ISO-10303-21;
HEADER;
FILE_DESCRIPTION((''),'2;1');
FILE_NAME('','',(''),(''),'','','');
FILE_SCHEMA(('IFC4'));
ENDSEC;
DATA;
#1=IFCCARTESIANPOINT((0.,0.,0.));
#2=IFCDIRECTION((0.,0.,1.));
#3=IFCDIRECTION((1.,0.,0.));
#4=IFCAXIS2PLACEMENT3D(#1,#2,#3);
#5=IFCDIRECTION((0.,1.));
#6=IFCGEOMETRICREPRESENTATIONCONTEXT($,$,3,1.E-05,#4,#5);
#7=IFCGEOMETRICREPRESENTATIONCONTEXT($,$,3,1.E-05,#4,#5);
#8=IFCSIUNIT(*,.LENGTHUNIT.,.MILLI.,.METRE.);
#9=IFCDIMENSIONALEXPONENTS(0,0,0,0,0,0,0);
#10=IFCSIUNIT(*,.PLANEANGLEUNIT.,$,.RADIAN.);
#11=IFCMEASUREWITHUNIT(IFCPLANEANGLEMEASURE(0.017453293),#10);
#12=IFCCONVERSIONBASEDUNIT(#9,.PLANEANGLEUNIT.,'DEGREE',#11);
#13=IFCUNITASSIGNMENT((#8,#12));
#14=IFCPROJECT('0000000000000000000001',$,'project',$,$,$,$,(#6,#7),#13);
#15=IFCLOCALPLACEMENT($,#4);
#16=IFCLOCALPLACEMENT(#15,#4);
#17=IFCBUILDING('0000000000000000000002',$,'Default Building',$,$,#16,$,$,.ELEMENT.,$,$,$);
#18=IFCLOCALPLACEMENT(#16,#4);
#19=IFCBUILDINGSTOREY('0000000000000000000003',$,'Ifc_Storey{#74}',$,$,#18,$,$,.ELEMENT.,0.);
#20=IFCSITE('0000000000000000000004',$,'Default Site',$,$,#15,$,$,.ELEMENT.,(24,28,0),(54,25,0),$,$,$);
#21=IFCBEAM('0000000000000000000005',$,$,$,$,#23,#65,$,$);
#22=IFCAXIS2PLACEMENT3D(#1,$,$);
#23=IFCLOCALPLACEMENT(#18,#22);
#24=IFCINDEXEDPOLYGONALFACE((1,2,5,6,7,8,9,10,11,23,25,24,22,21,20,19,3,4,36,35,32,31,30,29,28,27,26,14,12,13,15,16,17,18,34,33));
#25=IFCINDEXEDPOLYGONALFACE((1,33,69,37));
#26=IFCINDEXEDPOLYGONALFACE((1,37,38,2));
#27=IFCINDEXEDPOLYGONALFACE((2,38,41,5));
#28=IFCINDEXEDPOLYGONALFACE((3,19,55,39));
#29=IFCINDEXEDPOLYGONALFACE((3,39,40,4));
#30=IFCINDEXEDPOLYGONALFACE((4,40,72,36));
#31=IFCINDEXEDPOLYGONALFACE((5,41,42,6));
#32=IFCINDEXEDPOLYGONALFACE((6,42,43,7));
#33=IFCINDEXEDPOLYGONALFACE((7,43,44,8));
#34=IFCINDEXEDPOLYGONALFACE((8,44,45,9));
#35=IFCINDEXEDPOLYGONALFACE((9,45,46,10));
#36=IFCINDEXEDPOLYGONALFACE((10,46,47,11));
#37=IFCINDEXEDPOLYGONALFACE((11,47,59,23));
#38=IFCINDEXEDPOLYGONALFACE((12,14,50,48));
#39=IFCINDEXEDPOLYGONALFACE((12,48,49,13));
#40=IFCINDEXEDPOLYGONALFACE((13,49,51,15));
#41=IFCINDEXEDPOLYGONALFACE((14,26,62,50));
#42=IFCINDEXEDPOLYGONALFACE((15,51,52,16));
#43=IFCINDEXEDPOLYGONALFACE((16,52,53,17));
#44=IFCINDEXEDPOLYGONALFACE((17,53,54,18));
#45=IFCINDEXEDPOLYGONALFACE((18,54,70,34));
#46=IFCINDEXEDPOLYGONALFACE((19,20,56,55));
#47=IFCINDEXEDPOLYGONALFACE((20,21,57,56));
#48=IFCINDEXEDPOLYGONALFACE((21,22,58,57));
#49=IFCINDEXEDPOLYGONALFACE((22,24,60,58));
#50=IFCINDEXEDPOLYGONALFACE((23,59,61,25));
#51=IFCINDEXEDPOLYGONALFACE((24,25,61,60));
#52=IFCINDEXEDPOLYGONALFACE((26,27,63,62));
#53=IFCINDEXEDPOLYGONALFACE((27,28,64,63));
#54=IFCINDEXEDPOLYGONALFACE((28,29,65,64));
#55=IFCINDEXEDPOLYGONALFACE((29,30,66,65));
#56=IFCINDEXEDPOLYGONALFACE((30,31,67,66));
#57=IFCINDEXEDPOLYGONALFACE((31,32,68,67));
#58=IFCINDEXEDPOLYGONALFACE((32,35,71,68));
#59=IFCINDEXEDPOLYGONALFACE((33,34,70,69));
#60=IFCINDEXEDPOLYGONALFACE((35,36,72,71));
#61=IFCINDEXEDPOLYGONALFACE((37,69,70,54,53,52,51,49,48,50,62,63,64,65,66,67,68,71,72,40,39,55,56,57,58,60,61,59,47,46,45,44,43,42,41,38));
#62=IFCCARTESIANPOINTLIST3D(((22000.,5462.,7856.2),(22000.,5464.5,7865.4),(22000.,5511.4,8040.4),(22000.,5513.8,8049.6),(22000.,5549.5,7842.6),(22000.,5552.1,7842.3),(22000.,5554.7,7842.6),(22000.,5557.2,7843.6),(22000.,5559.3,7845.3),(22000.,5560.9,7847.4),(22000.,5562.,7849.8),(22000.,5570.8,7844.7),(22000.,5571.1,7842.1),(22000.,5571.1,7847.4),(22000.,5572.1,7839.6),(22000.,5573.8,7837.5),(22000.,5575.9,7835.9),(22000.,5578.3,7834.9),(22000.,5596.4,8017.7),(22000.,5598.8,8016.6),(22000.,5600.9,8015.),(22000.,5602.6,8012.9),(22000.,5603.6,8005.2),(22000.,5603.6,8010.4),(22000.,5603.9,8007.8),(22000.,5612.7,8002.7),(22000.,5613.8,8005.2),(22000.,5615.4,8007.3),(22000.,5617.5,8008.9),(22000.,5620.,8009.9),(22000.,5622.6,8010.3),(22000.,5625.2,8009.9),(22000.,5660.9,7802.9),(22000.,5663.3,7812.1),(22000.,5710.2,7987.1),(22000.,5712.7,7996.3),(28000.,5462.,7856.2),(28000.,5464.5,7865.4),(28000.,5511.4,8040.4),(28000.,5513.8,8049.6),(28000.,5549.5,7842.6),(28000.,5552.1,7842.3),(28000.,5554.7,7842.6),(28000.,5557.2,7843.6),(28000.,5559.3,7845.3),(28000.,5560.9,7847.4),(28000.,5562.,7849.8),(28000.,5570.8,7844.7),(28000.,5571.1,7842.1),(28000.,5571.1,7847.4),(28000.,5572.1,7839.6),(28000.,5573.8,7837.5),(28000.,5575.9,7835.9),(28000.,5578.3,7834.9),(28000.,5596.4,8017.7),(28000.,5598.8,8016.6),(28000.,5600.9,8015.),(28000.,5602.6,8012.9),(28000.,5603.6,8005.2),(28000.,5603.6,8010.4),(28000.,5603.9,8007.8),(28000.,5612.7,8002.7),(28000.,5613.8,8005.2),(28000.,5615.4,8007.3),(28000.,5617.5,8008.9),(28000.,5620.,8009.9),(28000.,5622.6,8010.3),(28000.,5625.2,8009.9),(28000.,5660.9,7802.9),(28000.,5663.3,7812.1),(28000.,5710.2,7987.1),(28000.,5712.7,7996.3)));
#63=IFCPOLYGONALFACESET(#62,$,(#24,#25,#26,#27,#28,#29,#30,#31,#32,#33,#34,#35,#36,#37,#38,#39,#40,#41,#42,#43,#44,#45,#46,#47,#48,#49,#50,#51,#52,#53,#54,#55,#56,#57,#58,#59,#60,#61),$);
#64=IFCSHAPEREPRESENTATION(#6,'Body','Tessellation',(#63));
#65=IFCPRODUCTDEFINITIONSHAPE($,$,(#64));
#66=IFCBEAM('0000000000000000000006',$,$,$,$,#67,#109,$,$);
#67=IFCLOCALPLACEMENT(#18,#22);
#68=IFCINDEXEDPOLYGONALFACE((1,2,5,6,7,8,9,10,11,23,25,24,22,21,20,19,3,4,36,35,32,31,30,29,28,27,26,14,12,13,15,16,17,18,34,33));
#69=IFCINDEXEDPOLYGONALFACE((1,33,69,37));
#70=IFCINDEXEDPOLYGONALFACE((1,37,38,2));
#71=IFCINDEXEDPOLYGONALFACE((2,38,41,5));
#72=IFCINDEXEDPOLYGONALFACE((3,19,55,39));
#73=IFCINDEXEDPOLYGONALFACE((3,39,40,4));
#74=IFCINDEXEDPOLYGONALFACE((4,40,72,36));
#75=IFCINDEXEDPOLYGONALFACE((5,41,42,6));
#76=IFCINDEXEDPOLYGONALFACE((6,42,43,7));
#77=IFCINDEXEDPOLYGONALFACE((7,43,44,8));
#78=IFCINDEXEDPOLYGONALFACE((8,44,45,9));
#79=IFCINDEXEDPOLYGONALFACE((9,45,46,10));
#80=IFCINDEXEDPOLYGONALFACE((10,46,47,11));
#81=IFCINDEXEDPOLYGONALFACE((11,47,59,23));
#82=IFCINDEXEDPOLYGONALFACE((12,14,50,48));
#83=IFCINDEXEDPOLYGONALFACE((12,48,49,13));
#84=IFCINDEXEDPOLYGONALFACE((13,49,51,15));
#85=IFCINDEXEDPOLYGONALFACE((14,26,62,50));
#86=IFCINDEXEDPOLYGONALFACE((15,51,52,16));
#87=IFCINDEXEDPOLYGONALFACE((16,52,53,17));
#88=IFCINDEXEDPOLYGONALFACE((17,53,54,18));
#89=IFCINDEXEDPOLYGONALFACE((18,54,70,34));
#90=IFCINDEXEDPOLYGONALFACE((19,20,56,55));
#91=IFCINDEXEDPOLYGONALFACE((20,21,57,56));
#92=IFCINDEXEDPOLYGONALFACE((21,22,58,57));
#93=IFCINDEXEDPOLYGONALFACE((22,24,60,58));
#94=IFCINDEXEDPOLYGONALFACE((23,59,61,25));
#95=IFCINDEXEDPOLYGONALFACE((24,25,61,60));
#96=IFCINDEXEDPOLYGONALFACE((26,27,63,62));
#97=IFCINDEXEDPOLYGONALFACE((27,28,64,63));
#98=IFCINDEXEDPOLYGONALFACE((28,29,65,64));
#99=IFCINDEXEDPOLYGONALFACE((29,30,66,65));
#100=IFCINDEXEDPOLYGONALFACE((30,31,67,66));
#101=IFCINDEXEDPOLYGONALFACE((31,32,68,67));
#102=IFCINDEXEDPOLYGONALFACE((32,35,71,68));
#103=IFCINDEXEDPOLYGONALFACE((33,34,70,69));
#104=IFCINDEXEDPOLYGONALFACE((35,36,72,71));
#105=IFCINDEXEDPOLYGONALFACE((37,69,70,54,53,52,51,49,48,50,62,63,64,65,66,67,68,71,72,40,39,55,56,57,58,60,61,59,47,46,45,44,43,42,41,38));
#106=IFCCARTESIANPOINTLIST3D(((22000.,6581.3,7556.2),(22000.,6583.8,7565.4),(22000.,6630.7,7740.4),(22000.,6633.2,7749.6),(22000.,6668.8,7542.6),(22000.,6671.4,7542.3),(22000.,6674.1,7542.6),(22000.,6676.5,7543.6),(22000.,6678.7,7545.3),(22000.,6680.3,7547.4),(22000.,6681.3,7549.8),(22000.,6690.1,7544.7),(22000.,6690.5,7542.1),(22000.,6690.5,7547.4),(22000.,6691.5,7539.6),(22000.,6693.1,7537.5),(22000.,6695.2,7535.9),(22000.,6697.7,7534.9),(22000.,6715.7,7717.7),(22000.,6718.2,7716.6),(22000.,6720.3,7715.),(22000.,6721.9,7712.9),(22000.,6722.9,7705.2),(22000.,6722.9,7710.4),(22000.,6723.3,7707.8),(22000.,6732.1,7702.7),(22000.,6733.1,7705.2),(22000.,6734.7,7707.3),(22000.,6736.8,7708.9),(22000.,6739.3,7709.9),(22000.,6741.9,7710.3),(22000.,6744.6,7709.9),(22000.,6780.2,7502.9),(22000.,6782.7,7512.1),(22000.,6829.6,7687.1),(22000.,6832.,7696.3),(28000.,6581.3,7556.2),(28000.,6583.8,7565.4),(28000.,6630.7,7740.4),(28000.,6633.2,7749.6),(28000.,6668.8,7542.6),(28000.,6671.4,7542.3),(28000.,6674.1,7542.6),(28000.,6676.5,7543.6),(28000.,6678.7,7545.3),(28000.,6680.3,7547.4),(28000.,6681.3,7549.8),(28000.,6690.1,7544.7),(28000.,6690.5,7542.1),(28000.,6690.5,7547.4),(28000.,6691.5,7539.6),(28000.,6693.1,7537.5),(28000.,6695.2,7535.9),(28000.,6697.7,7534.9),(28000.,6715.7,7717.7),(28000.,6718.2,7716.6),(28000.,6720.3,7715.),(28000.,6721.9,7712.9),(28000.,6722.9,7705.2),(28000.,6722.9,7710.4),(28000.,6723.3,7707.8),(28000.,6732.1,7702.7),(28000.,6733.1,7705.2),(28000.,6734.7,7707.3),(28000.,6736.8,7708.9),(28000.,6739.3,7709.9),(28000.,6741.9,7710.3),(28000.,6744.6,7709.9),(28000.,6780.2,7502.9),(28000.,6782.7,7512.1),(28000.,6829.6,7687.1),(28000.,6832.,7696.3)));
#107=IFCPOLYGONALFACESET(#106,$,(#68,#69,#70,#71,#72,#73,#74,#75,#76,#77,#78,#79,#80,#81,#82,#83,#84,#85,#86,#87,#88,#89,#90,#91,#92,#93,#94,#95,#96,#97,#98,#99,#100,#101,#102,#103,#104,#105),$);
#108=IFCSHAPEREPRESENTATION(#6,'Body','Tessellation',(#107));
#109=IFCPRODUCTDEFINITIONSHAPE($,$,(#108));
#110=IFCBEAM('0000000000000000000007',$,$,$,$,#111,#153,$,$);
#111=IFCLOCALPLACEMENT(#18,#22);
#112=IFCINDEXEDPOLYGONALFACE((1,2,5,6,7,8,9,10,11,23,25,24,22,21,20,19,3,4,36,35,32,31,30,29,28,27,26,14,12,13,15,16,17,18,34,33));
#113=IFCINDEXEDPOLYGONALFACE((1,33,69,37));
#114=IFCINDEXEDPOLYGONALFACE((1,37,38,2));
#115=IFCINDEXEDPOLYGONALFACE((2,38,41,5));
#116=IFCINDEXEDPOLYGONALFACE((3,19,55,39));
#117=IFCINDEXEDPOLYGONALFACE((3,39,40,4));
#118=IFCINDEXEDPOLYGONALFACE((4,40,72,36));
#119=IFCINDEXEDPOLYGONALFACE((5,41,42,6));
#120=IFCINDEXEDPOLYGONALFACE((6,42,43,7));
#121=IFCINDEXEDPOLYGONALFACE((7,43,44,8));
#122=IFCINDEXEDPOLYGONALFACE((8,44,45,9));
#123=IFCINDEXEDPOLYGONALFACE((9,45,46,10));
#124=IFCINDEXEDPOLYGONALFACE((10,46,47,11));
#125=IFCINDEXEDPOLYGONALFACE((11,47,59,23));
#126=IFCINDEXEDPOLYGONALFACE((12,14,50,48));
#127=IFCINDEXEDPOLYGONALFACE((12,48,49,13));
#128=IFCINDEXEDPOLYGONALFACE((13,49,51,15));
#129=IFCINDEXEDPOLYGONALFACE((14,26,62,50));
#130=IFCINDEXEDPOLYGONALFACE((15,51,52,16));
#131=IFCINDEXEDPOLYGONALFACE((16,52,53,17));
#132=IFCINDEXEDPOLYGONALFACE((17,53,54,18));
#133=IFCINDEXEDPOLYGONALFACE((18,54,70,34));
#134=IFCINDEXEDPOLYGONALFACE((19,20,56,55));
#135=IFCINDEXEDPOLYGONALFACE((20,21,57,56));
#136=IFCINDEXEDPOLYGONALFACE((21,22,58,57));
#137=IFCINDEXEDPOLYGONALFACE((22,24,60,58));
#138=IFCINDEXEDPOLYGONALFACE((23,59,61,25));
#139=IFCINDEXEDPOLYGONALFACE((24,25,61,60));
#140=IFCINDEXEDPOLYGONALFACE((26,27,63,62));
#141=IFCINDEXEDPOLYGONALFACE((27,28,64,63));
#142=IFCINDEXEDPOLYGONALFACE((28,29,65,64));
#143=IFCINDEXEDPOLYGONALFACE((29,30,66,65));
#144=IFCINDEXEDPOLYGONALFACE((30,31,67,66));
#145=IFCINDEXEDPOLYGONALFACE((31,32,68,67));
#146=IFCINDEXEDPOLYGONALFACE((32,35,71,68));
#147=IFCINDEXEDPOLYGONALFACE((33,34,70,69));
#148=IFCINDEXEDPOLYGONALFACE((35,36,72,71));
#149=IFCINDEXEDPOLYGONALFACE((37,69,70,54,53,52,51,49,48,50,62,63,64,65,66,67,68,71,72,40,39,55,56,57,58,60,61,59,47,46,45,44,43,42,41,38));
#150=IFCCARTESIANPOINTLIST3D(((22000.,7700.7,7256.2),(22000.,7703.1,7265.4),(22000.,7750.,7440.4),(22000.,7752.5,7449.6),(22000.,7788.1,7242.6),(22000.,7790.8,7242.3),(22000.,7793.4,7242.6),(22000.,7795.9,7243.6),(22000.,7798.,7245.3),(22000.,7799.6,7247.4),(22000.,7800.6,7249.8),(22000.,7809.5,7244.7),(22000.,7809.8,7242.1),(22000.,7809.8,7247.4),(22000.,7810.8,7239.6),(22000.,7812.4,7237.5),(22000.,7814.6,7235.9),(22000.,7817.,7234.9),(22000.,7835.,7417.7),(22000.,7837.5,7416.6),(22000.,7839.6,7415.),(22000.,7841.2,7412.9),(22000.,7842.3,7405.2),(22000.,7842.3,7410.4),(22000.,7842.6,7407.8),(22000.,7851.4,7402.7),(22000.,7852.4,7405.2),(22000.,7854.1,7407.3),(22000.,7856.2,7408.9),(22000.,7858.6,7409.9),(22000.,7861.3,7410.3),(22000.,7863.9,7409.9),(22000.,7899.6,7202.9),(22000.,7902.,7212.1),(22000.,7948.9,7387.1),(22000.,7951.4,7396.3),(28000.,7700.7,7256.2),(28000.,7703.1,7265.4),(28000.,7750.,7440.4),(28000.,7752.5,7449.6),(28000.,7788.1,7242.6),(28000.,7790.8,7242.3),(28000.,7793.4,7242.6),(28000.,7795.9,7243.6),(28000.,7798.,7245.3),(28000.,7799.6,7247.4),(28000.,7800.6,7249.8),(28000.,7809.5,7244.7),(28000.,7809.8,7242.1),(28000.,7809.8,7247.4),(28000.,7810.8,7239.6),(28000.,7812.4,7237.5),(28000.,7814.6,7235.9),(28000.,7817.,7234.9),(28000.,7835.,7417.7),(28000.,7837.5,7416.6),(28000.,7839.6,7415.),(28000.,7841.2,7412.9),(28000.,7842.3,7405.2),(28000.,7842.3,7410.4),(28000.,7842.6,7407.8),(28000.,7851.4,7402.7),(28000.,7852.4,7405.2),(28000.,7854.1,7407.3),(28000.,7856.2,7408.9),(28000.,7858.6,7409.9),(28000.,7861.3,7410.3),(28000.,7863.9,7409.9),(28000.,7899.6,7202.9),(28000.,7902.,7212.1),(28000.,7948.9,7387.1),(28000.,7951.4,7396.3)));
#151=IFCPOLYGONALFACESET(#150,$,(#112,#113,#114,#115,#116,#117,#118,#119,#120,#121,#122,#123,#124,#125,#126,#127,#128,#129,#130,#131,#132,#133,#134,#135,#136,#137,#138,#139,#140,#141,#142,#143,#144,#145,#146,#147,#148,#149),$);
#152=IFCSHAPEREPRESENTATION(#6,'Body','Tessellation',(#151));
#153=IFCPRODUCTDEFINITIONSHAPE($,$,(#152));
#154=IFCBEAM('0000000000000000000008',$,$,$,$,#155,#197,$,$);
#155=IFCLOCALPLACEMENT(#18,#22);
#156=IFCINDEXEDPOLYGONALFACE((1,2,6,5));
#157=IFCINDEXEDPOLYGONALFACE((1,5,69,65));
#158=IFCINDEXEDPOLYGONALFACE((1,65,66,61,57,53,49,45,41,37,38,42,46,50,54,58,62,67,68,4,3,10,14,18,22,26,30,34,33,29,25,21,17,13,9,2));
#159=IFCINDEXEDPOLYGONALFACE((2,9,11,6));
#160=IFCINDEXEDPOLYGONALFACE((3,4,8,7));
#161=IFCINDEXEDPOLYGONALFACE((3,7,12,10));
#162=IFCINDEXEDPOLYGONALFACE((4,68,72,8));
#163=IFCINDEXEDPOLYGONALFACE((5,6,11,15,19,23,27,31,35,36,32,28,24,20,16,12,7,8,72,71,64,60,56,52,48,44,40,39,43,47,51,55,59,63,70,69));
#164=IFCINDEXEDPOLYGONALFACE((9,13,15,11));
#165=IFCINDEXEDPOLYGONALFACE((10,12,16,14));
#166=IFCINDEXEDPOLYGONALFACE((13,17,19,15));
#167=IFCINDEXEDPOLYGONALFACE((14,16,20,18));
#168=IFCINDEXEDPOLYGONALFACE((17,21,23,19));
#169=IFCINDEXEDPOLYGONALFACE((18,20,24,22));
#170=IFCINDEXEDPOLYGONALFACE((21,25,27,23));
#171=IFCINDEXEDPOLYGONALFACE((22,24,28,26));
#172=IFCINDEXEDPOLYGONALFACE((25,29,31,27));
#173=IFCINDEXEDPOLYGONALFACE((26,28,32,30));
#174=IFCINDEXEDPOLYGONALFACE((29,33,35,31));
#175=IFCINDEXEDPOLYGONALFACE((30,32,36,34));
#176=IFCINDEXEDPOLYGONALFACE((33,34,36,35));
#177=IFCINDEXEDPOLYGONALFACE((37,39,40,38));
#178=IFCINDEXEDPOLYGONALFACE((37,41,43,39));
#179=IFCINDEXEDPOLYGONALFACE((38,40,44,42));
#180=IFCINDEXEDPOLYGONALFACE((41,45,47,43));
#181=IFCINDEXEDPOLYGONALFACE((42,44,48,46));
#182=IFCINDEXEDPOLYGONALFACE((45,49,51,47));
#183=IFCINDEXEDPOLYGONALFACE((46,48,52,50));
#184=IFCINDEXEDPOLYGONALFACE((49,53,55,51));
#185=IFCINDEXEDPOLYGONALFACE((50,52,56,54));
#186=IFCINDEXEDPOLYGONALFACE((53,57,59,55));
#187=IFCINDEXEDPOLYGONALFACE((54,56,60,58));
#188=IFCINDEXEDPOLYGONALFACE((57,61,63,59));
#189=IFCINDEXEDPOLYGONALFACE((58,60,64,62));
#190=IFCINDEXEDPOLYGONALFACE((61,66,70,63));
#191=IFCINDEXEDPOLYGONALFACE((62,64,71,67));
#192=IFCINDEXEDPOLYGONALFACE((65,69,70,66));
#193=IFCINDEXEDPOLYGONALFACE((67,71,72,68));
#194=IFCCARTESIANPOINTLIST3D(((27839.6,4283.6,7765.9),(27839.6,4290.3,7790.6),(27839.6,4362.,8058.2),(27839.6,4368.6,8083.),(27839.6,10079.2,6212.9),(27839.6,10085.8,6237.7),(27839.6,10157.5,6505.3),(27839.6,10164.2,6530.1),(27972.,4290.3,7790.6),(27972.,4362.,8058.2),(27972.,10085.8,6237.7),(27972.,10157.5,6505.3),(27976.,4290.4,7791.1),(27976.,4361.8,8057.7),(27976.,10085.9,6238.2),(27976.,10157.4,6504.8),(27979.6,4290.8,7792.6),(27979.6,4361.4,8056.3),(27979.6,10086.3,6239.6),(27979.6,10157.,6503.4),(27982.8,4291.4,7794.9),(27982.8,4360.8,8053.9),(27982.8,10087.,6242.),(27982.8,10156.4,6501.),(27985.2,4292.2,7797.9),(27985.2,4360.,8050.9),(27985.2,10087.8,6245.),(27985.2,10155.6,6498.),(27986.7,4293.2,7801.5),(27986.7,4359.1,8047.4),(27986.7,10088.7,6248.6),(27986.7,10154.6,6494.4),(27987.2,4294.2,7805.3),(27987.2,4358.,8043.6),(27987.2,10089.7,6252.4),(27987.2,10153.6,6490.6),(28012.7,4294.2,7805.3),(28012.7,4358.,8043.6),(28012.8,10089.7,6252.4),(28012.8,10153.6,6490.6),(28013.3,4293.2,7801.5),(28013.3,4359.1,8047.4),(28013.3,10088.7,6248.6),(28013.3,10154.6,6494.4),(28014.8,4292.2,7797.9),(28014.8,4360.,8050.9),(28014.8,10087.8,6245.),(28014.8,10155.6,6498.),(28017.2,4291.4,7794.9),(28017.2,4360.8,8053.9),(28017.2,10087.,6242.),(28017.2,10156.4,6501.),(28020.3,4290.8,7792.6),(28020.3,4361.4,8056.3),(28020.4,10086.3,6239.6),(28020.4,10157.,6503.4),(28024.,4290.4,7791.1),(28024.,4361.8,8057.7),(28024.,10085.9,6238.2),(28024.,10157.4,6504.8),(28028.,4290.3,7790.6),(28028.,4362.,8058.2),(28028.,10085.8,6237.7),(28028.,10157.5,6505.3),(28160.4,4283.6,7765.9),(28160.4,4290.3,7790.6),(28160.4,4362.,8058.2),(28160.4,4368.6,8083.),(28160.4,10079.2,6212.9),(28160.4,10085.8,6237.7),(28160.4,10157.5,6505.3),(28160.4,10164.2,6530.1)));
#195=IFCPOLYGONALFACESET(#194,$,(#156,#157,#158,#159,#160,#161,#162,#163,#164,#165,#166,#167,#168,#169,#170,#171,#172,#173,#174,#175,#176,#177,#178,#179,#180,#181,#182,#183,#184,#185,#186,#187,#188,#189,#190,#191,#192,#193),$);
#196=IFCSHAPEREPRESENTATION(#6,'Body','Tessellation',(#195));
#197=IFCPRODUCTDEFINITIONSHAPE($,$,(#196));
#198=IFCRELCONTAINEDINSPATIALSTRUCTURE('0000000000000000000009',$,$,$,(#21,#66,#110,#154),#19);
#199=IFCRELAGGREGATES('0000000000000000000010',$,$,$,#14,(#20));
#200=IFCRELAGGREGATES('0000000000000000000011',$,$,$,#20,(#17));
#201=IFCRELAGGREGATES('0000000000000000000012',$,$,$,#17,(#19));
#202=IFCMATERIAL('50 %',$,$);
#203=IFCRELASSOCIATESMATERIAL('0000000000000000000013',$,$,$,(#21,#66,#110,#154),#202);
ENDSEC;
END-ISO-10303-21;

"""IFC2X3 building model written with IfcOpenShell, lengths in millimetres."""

from ifc_helpers import new_model, entity, si_unit, converted_unit, direction, frame, origin_with_axes, origin_2d_with_axis, place, context, project, spatial, i_section, extrude, material, element, save


model = new_model("IFC2X3")

# Units and contexts
context_of_model_1 = context(None, 3, precision=1e-05, world=origin_with_axes(), true_north=direction((0.0, 1.0)))
context_of_model_2 = context(None, 3, precision=1e-05, world=origin_with_axes(), true_north=direction((0.0, 1.0)))
ifc_project = project(units=[si_unit("LENGTHUNIT", "METRE", prefix="MILLI"), converted_unit("PLANEANGLEUNIT", "DEGREE", entity("IfcPlaneAngleMeasure", 0.017453293), si_unit("PLANEANGLEUNIT", "RADIAN"), dimensions=[0, 0, 0, 0, 0, 0, 0])], contexts=[context_of_model_1, context_of_model_2])

# Site, building, storey
site_placement = place(None, origin_with_axes())
site = spatial("IfcSite", under=ifc_project, at=site_placement, Name="Default Site", CompositionType="ELEMENT", RefLatitude=(24, 28, 0), RefLongitude=(54, 25, 0))
building_placement = place(site_placement, origin_with_axes())
building = spatial("IfcBuilding", under=site, at=building_placement, Name="Default Building", CompositionType="ELEMENT")
storey_placement = place(building_placement, origin_with_axes())
storey = spatial("IfcBuildingStorey", under=building, at=storey_placement, Name="Ifc_Storey{#74}", CompositionType="ELEMENT", Elevation=0.0)

# Shared definitions
ifc_material_1 = material(Name="50 %")

# Beams
for number, where, z_axis, x_axis in (
    (1, (22000.0, 5587.4, 7926.3), (0.0, 0.258819, 0.965926), (1.0, 0.0, 0.0)),
    (2, (22000.0, 6706.7, 7626.3), (0.0, 0.258819, 0.965926), (1.0, 0.0, 0.0)),
    (3, (22000.0, 7826.0, 7326.3), (0.0, 0.258819, 0.965926), (1.0, 0.0, 0.0)),
):
    element("IfcBeam", number, at=place(storey_placement, frame(where, z_axis=z_axis, x_axis=x_axis)), inside=storey, material=ifc_material_1, context=context_of_model_1, shape_type="SweptSolid", body=[
        extrude(i_section(OverallWidth=205.9, OverallDepth=200.2, WebThickness=9.5, FlangeThickness=9.5, FilletRadius=10.2, at=origin_2d_with_axis()), frame((0.0, 0.0, 0.0), z_axis=(1.0, 0.0, 0.0), x_axis=(0.0, 1.0, 0.0)), (0.0, 0.0, 1.0), 6000.0),
    ])
beam_1_placement = place(storey_placement, frame((28000.0, 10121.7, 6371.5), z_axis=(0.0, 0.0, 1.0), x_axis=(0.0, -1.0, 0.0)))
element("IfcBeam", 4, at=beam_1_placement, inside=storey, material=ifc_material_1, context=context_of_model_1, shape_type="SweptSolid", body=[
    extrude(i_section(OverallWidth=320.9, OverallDepth=328.3, WebThickness=25.5, FlangeThickness=25.6, FilletRadius=15.2, at=origin_2d_with_axis()), frame((0.0, 0.0, 0.0), z_axis=(0.965926, 0.0, 0.258819), x_axis=(0.0, 1.0, 0.0)), (0.0, 0.0, 1.0), 6000.0),
])

save(model, "model.ifc")
